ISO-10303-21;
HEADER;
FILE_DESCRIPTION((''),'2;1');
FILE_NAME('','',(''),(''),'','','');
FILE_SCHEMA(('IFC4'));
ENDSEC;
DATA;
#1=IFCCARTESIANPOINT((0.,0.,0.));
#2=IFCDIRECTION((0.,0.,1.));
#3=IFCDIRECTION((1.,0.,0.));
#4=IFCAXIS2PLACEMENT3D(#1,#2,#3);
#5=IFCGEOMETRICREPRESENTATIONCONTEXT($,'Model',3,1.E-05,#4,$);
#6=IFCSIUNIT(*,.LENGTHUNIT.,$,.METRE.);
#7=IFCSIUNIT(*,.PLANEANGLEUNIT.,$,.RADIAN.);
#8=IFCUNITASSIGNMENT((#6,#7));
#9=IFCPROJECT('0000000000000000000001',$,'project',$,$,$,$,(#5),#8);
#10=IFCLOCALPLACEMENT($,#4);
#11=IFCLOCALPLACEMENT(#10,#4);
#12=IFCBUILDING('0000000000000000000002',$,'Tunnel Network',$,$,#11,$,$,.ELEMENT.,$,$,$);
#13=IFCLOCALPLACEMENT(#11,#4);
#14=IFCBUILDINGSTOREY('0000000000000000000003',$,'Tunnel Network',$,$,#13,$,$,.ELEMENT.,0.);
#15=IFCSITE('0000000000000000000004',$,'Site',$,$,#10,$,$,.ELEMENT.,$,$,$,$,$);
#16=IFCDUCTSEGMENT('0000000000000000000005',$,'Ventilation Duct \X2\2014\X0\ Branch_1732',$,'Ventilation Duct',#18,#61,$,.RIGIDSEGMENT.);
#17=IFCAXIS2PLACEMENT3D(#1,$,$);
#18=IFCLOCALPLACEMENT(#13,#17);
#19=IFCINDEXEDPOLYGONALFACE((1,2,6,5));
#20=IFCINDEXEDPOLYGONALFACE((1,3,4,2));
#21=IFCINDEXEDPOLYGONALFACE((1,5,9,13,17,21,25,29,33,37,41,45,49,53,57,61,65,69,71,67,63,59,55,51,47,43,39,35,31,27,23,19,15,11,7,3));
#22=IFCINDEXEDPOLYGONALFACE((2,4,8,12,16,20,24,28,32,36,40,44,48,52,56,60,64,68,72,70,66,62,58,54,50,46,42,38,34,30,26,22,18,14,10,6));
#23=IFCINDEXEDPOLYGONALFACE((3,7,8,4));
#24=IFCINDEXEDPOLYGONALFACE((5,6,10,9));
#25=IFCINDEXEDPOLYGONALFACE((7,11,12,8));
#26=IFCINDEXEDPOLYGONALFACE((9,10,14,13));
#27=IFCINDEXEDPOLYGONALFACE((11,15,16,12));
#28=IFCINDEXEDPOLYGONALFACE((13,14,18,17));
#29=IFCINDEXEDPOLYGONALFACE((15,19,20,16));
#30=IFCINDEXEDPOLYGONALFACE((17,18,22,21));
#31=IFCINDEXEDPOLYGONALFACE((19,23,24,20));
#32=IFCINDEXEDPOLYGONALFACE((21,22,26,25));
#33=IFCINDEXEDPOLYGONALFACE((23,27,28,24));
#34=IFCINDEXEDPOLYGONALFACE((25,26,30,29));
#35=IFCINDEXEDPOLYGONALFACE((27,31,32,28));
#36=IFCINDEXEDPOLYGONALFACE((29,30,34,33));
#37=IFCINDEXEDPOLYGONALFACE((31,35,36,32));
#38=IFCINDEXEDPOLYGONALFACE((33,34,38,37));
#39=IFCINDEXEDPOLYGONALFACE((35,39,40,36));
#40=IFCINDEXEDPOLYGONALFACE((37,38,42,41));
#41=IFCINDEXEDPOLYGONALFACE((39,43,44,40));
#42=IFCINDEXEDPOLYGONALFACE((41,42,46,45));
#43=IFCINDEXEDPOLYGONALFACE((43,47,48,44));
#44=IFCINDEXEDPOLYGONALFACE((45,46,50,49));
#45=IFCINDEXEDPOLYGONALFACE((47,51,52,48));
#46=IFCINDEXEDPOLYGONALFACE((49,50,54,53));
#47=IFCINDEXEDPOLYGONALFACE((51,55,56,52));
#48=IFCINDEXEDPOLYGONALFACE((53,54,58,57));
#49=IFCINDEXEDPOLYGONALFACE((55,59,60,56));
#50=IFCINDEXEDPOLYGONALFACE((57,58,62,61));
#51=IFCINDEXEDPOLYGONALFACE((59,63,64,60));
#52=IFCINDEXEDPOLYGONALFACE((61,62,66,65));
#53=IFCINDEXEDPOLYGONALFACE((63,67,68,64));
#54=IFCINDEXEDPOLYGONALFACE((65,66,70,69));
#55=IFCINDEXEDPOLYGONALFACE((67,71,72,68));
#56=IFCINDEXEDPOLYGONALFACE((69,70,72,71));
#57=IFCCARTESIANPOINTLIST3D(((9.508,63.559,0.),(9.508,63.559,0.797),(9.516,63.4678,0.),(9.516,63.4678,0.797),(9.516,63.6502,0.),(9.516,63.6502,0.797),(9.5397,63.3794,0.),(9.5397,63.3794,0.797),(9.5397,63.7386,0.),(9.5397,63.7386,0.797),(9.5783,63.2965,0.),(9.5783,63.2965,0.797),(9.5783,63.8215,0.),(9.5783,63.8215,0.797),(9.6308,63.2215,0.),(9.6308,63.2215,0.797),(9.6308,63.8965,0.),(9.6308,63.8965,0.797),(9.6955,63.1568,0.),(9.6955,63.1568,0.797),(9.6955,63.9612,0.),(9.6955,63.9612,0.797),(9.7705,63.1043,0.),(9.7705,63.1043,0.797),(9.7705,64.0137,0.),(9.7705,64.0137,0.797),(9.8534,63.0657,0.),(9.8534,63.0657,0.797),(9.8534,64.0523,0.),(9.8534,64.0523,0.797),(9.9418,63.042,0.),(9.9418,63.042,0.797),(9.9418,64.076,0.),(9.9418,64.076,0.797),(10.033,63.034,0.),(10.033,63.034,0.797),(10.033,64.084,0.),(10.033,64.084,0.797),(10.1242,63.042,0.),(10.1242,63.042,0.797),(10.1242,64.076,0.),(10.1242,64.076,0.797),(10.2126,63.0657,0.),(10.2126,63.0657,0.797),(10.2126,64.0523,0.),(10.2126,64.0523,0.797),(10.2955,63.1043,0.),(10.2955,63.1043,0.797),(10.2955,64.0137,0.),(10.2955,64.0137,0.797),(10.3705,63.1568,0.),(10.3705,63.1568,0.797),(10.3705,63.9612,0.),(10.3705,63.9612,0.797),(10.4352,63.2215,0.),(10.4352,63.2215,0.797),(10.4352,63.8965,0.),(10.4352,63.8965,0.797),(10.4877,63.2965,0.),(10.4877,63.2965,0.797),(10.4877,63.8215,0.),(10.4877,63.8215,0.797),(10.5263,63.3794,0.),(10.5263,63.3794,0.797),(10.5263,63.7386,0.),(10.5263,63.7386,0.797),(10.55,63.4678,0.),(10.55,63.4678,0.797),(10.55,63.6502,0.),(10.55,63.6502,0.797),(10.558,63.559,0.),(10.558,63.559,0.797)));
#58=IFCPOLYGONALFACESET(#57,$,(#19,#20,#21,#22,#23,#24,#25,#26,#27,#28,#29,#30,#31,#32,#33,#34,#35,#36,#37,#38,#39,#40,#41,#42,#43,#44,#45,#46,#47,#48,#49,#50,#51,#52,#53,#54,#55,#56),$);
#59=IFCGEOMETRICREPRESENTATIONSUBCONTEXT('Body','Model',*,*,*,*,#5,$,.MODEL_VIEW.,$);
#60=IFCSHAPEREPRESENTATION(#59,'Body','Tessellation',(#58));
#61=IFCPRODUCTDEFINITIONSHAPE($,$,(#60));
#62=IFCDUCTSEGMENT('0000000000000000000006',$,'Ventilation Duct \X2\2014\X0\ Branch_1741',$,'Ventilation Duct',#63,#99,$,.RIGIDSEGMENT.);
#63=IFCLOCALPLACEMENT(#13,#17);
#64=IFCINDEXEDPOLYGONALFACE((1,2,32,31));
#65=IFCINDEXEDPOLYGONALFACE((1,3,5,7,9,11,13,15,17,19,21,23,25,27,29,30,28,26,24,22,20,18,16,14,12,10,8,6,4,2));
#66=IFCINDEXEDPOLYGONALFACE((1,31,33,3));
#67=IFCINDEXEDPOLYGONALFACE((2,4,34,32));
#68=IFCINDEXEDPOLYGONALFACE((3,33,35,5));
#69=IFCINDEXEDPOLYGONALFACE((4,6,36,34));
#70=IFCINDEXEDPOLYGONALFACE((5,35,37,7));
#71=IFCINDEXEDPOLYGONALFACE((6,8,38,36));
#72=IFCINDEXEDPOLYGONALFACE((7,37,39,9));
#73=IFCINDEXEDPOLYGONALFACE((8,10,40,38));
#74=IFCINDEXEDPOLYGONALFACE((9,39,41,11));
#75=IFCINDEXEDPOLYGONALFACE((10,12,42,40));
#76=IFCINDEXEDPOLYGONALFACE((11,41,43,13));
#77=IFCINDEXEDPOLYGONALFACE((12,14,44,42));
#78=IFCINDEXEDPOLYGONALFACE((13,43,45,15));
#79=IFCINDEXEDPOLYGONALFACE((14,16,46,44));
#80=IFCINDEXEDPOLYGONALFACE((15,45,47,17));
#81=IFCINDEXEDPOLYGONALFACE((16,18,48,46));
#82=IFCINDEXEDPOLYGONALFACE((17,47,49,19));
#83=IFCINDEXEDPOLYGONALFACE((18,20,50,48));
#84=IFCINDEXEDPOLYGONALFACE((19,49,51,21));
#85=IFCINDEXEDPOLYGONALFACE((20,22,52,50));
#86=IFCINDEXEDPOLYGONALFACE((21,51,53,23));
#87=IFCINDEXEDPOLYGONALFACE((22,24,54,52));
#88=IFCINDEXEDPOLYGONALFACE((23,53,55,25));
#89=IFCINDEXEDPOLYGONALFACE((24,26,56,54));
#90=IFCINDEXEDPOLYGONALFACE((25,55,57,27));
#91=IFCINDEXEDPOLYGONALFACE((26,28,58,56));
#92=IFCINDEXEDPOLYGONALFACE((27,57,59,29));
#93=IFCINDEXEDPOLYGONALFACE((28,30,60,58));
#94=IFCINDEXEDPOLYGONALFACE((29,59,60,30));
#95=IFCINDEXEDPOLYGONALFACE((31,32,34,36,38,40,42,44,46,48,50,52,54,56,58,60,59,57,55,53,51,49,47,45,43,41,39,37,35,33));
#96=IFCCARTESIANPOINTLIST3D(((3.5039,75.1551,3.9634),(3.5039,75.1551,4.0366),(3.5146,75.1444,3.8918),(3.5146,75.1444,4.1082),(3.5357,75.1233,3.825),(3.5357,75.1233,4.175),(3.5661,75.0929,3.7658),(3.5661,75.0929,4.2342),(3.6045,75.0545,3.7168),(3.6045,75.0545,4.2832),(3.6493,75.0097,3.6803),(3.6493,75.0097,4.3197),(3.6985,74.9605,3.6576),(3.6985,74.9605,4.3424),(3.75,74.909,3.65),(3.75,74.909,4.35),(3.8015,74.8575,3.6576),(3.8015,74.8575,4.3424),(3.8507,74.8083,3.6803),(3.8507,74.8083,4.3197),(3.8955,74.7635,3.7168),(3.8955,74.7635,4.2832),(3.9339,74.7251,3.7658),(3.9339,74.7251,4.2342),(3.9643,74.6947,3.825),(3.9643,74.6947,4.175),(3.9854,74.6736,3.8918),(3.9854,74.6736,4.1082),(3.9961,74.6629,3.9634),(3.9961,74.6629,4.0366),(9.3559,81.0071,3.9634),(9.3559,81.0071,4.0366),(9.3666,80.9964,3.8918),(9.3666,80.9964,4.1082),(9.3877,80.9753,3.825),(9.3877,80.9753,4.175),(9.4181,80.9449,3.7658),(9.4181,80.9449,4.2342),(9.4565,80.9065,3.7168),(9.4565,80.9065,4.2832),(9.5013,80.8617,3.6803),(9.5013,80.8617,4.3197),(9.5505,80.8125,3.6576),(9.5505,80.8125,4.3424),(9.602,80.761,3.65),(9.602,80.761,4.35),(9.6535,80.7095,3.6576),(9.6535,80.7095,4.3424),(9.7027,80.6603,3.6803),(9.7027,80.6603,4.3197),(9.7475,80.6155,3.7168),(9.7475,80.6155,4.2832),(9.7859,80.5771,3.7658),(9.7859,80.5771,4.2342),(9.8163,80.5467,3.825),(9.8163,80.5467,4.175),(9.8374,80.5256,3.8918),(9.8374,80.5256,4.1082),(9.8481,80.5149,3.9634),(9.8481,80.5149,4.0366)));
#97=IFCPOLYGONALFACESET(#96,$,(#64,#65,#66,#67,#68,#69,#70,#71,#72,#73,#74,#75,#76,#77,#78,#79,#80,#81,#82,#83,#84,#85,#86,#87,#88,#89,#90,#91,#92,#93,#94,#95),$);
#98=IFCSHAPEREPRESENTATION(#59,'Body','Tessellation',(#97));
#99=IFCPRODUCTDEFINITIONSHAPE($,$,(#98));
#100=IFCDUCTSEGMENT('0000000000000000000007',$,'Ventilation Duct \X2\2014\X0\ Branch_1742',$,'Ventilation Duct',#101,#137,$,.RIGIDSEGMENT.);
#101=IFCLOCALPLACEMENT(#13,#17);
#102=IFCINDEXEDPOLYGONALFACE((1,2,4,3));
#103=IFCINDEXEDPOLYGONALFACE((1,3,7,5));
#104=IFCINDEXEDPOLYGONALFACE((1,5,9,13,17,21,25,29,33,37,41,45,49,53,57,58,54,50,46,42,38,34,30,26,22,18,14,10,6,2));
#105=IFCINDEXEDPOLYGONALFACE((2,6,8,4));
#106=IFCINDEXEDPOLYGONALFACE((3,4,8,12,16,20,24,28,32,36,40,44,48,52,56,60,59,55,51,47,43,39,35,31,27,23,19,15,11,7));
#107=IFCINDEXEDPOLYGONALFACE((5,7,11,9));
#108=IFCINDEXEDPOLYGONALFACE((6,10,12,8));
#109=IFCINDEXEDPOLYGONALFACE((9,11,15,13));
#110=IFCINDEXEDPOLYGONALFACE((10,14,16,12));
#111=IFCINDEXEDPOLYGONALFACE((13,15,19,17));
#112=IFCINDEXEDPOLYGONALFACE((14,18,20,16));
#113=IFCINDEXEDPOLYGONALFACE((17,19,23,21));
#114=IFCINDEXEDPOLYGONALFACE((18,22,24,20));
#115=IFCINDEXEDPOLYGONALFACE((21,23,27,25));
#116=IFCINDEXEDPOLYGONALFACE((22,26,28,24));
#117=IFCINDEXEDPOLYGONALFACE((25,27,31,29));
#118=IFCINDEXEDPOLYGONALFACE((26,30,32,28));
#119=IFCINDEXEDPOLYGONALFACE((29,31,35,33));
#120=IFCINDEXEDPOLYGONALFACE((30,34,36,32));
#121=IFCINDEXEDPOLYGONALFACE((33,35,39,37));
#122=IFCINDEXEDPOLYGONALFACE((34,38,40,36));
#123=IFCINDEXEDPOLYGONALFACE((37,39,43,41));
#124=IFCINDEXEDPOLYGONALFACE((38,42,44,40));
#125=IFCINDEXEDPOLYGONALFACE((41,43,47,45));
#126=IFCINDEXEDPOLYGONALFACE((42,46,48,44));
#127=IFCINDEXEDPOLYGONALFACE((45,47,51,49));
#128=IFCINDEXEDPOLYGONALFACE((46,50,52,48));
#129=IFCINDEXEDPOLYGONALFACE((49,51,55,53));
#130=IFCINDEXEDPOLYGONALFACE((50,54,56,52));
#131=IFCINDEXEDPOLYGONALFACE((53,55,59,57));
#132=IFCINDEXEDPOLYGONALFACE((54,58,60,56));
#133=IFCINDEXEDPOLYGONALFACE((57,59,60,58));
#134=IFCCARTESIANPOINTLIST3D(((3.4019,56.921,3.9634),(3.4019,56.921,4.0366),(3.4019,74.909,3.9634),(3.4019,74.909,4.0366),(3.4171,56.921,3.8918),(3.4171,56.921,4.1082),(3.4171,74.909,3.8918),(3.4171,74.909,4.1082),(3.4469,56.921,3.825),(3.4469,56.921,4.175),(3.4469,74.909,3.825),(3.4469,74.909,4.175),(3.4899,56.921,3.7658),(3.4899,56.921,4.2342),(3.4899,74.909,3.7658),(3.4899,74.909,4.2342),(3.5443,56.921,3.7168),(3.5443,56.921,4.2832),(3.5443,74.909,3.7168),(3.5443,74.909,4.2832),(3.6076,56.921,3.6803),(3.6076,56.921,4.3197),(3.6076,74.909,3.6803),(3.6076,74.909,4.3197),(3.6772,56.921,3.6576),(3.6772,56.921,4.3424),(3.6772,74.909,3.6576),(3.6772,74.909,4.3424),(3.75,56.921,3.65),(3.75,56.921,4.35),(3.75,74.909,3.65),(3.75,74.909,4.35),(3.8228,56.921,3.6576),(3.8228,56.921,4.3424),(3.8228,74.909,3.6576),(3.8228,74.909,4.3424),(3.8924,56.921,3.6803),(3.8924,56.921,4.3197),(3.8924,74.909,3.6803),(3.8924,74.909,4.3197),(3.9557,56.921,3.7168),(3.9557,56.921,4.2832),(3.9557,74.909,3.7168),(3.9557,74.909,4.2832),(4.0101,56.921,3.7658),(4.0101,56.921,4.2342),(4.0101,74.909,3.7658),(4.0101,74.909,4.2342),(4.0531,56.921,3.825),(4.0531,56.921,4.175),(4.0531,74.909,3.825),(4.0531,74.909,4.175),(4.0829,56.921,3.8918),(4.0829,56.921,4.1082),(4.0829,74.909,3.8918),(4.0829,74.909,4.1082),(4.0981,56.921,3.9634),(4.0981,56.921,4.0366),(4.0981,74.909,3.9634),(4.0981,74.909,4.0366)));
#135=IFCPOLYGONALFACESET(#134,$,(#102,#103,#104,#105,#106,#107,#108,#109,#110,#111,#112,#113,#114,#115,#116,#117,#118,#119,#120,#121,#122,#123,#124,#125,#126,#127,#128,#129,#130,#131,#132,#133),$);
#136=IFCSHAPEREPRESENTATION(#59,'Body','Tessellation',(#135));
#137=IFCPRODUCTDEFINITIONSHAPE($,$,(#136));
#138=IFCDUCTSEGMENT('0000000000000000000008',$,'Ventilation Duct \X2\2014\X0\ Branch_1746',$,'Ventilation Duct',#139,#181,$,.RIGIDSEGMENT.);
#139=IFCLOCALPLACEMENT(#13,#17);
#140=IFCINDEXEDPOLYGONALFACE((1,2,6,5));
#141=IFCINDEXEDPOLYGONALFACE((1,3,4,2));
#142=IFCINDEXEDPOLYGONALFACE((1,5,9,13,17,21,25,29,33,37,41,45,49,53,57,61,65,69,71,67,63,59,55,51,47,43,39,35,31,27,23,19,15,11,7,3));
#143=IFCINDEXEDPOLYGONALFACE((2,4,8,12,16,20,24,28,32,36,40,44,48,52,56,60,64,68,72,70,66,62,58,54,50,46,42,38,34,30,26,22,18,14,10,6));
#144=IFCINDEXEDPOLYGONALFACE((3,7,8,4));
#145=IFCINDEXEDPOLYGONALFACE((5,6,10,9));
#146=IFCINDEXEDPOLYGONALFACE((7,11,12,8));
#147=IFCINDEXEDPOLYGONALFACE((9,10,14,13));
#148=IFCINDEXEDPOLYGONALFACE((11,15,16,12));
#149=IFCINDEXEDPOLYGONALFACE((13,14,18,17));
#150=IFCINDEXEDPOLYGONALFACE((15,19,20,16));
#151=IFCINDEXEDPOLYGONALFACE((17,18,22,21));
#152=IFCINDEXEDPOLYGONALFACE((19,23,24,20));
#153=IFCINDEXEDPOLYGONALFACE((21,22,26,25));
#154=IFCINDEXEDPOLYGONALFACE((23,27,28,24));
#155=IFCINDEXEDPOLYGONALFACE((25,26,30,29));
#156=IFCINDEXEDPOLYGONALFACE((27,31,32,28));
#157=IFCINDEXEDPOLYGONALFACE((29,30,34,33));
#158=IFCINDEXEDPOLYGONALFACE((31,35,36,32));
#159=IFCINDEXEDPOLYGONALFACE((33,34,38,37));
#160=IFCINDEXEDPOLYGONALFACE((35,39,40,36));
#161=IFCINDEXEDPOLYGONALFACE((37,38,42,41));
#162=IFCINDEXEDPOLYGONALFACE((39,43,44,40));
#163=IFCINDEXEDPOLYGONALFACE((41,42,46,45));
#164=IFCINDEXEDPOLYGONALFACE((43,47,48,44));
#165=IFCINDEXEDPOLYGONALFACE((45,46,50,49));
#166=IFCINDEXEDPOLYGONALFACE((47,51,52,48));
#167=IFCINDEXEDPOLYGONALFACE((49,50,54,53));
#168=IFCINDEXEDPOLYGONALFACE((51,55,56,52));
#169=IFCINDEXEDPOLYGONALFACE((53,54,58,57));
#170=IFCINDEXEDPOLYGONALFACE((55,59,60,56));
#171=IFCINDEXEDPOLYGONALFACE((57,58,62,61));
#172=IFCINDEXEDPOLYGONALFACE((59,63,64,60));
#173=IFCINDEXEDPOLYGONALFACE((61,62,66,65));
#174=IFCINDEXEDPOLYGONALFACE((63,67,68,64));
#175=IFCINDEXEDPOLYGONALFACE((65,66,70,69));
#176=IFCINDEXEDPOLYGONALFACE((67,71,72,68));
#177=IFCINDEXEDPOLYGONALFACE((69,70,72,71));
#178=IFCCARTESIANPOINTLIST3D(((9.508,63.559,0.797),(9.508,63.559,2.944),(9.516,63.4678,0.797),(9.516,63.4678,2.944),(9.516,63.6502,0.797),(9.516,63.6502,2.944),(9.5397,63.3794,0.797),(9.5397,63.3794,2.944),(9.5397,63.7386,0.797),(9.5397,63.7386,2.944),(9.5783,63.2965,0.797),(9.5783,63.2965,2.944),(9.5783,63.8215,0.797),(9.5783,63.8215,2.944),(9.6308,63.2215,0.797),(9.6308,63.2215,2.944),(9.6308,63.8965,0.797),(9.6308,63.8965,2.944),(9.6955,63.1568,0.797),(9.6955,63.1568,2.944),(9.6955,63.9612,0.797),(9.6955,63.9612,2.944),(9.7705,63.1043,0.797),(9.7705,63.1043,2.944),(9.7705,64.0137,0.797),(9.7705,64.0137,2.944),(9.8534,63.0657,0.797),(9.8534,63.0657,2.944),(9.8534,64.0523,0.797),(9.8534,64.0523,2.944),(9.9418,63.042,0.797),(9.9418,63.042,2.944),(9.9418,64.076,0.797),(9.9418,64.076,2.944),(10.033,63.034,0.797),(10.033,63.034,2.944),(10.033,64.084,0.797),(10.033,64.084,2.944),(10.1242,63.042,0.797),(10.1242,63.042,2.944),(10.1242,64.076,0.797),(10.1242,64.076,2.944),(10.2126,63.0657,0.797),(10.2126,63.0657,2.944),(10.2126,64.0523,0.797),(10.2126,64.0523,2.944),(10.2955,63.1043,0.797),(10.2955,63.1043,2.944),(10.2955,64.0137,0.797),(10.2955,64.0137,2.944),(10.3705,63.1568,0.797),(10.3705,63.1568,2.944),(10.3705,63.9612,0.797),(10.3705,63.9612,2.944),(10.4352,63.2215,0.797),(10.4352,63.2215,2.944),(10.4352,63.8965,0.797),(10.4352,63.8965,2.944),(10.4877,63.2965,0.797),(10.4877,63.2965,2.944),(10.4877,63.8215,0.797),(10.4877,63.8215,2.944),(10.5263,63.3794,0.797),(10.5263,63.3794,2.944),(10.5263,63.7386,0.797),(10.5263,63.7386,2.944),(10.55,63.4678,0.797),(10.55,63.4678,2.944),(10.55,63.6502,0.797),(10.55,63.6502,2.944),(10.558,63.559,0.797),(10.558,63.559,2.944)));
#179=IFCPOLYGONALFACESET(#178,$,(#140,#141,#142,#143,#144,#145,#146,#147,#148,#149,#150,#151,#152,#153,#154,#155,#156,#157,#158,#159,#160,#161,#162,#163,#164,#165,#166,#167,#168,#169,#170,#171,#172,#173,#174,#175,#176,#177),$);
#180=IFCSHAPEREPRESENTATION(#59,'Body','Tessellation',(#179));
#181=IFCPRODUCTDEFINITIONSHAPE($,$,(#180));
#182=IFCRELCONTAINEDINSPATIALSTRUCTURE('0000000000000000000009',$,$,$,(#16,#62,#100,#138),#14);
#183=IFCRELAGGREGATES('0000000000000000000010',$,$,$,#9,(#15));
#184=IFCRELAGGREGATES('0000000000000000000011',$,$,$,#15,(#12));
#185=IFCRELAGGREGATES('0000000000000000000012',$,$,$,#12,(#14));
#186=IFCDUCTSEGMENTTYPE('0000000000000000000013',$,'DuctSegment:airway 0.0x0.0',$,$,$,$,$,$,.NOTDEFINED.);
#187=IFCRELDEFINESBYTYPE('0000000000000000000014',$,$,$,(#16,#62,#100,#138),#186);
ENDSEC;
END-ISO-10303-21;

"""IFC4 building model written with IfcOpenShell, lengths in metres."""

from ifc_helpers import new_model, si_unit, frame, origin_with_axes, origin_2d_with_axis, place, context, subcontext, project, spatial, circle, extrude, type_object, element, save


model = new_model("IFC4")

# Units and contexts
model_context = context("Model", 3, precision=1e-05, world=origin_with_axes())
body_context = subcontext(model_context, "Body", "Model", "MODEL_VIEW")
ifc_project = project(units=[si_unit("LENGTHUNIT", "METRE"), si_unit("PLANEANGLEUNIT", "RADIAN")], contexts=[model_context])

# Site, building, storey
site_placement = place(None, origin_with_axes())
site = spatial("IfcSite", under=ifc_project, at=site_placement, Name="Site", CompositionType="ELEMENT")
building_placement = place(site_placement, origin_with_axes())
building = spatial("IfcBuilding", under=site, at=building_placement, Name="Tunnel Network", CompositionType="ELEMENT")
storey_placement = place(building_placement, origin_with_axes())
storey = spatial("IfcBuildingStorey", under=building, at=storey_placement, Name="Tunnel Network", CompositionType="ELEMENT", Elevation=0.0)

# Duct segments
duct_segment_type = type_object("IfcDuctSegmentType", Name="DuctSegment:airway 0.0x0.0")
duct_segment_1_placement = place(storey_placement, frame((10.033, 63.559, 0.0), z_axis=(0.0, 0.0, 1.0), x_axis=(1.0, 0.0, 0.0)))
element("IfcDuctSegment", 1, at=duct_segment_1_placement, inside=storey, type_object=duct_segment_type, Name="Ventilation Duct — Branch_1732", ObjectType="Ventilation Duct", PredefinedType="RIGIDSEGMENT", context=body_context, shape_type="SweptSolid", body=[
    extrude(circle(Radius=0.525, at=origin_2d_with_axis()), origin_with_axes(), (0.0, 0.0, 1.0), 0.797),
])
duct_segment_2_placement = place(storey_placement, frame((9.602, 80.761, 4.0), z_axis=(-0.707107, -0.707106, 0.0), x_axis=(0.0, 0.0, 1.0)))
element("IfcDuctSegment", 2, at=duct_segment_2_placement, inside=storey, type_object=duct_segment_type, Name="Ventilation Duct — Branch_1741", ObjectType="Ventilation Duct", PredefinedType="RIGIDSEGMENT", context=body_context, shape_type="SweptSolid", body=[
    extrude(circle(Radius=0.35, at=origin_2d_with_axis()), origin_with_axes(), (0.0, 0.0, 1.0), 8.276),
])
duct_segment_3_placement = place(storey_placement, frame((3.75, 74.909, 4.0), z_axis=(0.0, -1.0, 0.0), x_axis=(0.0, 0.0, 1.0)))
element("IfcDuctSegment", 3, at=duct_segment_3_placement, inside=storey, type_object=duct_segment_type, Name="Ventilation Duct — Branch_1742", ObjectType="Ventilation Duct", PredefinedType="RIGIDSEGMENT", context=body_context, shape_type="SweptSolid", body=[
    extrude(circle(Radius=0.35, at=origin_2d_with_axis()), origin_with_axes(), (0.0, 0.0, 1.0), 17.988),
])
duct_segment_4_placement = place(storey_placement, frame((10.033, 63.559, 0.797), z_axis=(0.0, 0.0, 1.0), x_axis=(1.0, 0.0, 0.0)))
element("IfcDuctSegment", 4, at=duct_segment_4_placement, inside=storey, type_object=duct_segment_type, Name="Ventilation Duct — Branch_1746", ObjectType="Ventilation Duct", PredefinedType="RIGIDSEGMENT", context=body_context, shape_type="SweptSolid", body=[
    extrude(circle(Radius=0.525, at=origin_2d_with_axis()), origin_with_axes(), (0.0, 0.0, 1.0), 2.147),
])

save(model, "model.ifc")
